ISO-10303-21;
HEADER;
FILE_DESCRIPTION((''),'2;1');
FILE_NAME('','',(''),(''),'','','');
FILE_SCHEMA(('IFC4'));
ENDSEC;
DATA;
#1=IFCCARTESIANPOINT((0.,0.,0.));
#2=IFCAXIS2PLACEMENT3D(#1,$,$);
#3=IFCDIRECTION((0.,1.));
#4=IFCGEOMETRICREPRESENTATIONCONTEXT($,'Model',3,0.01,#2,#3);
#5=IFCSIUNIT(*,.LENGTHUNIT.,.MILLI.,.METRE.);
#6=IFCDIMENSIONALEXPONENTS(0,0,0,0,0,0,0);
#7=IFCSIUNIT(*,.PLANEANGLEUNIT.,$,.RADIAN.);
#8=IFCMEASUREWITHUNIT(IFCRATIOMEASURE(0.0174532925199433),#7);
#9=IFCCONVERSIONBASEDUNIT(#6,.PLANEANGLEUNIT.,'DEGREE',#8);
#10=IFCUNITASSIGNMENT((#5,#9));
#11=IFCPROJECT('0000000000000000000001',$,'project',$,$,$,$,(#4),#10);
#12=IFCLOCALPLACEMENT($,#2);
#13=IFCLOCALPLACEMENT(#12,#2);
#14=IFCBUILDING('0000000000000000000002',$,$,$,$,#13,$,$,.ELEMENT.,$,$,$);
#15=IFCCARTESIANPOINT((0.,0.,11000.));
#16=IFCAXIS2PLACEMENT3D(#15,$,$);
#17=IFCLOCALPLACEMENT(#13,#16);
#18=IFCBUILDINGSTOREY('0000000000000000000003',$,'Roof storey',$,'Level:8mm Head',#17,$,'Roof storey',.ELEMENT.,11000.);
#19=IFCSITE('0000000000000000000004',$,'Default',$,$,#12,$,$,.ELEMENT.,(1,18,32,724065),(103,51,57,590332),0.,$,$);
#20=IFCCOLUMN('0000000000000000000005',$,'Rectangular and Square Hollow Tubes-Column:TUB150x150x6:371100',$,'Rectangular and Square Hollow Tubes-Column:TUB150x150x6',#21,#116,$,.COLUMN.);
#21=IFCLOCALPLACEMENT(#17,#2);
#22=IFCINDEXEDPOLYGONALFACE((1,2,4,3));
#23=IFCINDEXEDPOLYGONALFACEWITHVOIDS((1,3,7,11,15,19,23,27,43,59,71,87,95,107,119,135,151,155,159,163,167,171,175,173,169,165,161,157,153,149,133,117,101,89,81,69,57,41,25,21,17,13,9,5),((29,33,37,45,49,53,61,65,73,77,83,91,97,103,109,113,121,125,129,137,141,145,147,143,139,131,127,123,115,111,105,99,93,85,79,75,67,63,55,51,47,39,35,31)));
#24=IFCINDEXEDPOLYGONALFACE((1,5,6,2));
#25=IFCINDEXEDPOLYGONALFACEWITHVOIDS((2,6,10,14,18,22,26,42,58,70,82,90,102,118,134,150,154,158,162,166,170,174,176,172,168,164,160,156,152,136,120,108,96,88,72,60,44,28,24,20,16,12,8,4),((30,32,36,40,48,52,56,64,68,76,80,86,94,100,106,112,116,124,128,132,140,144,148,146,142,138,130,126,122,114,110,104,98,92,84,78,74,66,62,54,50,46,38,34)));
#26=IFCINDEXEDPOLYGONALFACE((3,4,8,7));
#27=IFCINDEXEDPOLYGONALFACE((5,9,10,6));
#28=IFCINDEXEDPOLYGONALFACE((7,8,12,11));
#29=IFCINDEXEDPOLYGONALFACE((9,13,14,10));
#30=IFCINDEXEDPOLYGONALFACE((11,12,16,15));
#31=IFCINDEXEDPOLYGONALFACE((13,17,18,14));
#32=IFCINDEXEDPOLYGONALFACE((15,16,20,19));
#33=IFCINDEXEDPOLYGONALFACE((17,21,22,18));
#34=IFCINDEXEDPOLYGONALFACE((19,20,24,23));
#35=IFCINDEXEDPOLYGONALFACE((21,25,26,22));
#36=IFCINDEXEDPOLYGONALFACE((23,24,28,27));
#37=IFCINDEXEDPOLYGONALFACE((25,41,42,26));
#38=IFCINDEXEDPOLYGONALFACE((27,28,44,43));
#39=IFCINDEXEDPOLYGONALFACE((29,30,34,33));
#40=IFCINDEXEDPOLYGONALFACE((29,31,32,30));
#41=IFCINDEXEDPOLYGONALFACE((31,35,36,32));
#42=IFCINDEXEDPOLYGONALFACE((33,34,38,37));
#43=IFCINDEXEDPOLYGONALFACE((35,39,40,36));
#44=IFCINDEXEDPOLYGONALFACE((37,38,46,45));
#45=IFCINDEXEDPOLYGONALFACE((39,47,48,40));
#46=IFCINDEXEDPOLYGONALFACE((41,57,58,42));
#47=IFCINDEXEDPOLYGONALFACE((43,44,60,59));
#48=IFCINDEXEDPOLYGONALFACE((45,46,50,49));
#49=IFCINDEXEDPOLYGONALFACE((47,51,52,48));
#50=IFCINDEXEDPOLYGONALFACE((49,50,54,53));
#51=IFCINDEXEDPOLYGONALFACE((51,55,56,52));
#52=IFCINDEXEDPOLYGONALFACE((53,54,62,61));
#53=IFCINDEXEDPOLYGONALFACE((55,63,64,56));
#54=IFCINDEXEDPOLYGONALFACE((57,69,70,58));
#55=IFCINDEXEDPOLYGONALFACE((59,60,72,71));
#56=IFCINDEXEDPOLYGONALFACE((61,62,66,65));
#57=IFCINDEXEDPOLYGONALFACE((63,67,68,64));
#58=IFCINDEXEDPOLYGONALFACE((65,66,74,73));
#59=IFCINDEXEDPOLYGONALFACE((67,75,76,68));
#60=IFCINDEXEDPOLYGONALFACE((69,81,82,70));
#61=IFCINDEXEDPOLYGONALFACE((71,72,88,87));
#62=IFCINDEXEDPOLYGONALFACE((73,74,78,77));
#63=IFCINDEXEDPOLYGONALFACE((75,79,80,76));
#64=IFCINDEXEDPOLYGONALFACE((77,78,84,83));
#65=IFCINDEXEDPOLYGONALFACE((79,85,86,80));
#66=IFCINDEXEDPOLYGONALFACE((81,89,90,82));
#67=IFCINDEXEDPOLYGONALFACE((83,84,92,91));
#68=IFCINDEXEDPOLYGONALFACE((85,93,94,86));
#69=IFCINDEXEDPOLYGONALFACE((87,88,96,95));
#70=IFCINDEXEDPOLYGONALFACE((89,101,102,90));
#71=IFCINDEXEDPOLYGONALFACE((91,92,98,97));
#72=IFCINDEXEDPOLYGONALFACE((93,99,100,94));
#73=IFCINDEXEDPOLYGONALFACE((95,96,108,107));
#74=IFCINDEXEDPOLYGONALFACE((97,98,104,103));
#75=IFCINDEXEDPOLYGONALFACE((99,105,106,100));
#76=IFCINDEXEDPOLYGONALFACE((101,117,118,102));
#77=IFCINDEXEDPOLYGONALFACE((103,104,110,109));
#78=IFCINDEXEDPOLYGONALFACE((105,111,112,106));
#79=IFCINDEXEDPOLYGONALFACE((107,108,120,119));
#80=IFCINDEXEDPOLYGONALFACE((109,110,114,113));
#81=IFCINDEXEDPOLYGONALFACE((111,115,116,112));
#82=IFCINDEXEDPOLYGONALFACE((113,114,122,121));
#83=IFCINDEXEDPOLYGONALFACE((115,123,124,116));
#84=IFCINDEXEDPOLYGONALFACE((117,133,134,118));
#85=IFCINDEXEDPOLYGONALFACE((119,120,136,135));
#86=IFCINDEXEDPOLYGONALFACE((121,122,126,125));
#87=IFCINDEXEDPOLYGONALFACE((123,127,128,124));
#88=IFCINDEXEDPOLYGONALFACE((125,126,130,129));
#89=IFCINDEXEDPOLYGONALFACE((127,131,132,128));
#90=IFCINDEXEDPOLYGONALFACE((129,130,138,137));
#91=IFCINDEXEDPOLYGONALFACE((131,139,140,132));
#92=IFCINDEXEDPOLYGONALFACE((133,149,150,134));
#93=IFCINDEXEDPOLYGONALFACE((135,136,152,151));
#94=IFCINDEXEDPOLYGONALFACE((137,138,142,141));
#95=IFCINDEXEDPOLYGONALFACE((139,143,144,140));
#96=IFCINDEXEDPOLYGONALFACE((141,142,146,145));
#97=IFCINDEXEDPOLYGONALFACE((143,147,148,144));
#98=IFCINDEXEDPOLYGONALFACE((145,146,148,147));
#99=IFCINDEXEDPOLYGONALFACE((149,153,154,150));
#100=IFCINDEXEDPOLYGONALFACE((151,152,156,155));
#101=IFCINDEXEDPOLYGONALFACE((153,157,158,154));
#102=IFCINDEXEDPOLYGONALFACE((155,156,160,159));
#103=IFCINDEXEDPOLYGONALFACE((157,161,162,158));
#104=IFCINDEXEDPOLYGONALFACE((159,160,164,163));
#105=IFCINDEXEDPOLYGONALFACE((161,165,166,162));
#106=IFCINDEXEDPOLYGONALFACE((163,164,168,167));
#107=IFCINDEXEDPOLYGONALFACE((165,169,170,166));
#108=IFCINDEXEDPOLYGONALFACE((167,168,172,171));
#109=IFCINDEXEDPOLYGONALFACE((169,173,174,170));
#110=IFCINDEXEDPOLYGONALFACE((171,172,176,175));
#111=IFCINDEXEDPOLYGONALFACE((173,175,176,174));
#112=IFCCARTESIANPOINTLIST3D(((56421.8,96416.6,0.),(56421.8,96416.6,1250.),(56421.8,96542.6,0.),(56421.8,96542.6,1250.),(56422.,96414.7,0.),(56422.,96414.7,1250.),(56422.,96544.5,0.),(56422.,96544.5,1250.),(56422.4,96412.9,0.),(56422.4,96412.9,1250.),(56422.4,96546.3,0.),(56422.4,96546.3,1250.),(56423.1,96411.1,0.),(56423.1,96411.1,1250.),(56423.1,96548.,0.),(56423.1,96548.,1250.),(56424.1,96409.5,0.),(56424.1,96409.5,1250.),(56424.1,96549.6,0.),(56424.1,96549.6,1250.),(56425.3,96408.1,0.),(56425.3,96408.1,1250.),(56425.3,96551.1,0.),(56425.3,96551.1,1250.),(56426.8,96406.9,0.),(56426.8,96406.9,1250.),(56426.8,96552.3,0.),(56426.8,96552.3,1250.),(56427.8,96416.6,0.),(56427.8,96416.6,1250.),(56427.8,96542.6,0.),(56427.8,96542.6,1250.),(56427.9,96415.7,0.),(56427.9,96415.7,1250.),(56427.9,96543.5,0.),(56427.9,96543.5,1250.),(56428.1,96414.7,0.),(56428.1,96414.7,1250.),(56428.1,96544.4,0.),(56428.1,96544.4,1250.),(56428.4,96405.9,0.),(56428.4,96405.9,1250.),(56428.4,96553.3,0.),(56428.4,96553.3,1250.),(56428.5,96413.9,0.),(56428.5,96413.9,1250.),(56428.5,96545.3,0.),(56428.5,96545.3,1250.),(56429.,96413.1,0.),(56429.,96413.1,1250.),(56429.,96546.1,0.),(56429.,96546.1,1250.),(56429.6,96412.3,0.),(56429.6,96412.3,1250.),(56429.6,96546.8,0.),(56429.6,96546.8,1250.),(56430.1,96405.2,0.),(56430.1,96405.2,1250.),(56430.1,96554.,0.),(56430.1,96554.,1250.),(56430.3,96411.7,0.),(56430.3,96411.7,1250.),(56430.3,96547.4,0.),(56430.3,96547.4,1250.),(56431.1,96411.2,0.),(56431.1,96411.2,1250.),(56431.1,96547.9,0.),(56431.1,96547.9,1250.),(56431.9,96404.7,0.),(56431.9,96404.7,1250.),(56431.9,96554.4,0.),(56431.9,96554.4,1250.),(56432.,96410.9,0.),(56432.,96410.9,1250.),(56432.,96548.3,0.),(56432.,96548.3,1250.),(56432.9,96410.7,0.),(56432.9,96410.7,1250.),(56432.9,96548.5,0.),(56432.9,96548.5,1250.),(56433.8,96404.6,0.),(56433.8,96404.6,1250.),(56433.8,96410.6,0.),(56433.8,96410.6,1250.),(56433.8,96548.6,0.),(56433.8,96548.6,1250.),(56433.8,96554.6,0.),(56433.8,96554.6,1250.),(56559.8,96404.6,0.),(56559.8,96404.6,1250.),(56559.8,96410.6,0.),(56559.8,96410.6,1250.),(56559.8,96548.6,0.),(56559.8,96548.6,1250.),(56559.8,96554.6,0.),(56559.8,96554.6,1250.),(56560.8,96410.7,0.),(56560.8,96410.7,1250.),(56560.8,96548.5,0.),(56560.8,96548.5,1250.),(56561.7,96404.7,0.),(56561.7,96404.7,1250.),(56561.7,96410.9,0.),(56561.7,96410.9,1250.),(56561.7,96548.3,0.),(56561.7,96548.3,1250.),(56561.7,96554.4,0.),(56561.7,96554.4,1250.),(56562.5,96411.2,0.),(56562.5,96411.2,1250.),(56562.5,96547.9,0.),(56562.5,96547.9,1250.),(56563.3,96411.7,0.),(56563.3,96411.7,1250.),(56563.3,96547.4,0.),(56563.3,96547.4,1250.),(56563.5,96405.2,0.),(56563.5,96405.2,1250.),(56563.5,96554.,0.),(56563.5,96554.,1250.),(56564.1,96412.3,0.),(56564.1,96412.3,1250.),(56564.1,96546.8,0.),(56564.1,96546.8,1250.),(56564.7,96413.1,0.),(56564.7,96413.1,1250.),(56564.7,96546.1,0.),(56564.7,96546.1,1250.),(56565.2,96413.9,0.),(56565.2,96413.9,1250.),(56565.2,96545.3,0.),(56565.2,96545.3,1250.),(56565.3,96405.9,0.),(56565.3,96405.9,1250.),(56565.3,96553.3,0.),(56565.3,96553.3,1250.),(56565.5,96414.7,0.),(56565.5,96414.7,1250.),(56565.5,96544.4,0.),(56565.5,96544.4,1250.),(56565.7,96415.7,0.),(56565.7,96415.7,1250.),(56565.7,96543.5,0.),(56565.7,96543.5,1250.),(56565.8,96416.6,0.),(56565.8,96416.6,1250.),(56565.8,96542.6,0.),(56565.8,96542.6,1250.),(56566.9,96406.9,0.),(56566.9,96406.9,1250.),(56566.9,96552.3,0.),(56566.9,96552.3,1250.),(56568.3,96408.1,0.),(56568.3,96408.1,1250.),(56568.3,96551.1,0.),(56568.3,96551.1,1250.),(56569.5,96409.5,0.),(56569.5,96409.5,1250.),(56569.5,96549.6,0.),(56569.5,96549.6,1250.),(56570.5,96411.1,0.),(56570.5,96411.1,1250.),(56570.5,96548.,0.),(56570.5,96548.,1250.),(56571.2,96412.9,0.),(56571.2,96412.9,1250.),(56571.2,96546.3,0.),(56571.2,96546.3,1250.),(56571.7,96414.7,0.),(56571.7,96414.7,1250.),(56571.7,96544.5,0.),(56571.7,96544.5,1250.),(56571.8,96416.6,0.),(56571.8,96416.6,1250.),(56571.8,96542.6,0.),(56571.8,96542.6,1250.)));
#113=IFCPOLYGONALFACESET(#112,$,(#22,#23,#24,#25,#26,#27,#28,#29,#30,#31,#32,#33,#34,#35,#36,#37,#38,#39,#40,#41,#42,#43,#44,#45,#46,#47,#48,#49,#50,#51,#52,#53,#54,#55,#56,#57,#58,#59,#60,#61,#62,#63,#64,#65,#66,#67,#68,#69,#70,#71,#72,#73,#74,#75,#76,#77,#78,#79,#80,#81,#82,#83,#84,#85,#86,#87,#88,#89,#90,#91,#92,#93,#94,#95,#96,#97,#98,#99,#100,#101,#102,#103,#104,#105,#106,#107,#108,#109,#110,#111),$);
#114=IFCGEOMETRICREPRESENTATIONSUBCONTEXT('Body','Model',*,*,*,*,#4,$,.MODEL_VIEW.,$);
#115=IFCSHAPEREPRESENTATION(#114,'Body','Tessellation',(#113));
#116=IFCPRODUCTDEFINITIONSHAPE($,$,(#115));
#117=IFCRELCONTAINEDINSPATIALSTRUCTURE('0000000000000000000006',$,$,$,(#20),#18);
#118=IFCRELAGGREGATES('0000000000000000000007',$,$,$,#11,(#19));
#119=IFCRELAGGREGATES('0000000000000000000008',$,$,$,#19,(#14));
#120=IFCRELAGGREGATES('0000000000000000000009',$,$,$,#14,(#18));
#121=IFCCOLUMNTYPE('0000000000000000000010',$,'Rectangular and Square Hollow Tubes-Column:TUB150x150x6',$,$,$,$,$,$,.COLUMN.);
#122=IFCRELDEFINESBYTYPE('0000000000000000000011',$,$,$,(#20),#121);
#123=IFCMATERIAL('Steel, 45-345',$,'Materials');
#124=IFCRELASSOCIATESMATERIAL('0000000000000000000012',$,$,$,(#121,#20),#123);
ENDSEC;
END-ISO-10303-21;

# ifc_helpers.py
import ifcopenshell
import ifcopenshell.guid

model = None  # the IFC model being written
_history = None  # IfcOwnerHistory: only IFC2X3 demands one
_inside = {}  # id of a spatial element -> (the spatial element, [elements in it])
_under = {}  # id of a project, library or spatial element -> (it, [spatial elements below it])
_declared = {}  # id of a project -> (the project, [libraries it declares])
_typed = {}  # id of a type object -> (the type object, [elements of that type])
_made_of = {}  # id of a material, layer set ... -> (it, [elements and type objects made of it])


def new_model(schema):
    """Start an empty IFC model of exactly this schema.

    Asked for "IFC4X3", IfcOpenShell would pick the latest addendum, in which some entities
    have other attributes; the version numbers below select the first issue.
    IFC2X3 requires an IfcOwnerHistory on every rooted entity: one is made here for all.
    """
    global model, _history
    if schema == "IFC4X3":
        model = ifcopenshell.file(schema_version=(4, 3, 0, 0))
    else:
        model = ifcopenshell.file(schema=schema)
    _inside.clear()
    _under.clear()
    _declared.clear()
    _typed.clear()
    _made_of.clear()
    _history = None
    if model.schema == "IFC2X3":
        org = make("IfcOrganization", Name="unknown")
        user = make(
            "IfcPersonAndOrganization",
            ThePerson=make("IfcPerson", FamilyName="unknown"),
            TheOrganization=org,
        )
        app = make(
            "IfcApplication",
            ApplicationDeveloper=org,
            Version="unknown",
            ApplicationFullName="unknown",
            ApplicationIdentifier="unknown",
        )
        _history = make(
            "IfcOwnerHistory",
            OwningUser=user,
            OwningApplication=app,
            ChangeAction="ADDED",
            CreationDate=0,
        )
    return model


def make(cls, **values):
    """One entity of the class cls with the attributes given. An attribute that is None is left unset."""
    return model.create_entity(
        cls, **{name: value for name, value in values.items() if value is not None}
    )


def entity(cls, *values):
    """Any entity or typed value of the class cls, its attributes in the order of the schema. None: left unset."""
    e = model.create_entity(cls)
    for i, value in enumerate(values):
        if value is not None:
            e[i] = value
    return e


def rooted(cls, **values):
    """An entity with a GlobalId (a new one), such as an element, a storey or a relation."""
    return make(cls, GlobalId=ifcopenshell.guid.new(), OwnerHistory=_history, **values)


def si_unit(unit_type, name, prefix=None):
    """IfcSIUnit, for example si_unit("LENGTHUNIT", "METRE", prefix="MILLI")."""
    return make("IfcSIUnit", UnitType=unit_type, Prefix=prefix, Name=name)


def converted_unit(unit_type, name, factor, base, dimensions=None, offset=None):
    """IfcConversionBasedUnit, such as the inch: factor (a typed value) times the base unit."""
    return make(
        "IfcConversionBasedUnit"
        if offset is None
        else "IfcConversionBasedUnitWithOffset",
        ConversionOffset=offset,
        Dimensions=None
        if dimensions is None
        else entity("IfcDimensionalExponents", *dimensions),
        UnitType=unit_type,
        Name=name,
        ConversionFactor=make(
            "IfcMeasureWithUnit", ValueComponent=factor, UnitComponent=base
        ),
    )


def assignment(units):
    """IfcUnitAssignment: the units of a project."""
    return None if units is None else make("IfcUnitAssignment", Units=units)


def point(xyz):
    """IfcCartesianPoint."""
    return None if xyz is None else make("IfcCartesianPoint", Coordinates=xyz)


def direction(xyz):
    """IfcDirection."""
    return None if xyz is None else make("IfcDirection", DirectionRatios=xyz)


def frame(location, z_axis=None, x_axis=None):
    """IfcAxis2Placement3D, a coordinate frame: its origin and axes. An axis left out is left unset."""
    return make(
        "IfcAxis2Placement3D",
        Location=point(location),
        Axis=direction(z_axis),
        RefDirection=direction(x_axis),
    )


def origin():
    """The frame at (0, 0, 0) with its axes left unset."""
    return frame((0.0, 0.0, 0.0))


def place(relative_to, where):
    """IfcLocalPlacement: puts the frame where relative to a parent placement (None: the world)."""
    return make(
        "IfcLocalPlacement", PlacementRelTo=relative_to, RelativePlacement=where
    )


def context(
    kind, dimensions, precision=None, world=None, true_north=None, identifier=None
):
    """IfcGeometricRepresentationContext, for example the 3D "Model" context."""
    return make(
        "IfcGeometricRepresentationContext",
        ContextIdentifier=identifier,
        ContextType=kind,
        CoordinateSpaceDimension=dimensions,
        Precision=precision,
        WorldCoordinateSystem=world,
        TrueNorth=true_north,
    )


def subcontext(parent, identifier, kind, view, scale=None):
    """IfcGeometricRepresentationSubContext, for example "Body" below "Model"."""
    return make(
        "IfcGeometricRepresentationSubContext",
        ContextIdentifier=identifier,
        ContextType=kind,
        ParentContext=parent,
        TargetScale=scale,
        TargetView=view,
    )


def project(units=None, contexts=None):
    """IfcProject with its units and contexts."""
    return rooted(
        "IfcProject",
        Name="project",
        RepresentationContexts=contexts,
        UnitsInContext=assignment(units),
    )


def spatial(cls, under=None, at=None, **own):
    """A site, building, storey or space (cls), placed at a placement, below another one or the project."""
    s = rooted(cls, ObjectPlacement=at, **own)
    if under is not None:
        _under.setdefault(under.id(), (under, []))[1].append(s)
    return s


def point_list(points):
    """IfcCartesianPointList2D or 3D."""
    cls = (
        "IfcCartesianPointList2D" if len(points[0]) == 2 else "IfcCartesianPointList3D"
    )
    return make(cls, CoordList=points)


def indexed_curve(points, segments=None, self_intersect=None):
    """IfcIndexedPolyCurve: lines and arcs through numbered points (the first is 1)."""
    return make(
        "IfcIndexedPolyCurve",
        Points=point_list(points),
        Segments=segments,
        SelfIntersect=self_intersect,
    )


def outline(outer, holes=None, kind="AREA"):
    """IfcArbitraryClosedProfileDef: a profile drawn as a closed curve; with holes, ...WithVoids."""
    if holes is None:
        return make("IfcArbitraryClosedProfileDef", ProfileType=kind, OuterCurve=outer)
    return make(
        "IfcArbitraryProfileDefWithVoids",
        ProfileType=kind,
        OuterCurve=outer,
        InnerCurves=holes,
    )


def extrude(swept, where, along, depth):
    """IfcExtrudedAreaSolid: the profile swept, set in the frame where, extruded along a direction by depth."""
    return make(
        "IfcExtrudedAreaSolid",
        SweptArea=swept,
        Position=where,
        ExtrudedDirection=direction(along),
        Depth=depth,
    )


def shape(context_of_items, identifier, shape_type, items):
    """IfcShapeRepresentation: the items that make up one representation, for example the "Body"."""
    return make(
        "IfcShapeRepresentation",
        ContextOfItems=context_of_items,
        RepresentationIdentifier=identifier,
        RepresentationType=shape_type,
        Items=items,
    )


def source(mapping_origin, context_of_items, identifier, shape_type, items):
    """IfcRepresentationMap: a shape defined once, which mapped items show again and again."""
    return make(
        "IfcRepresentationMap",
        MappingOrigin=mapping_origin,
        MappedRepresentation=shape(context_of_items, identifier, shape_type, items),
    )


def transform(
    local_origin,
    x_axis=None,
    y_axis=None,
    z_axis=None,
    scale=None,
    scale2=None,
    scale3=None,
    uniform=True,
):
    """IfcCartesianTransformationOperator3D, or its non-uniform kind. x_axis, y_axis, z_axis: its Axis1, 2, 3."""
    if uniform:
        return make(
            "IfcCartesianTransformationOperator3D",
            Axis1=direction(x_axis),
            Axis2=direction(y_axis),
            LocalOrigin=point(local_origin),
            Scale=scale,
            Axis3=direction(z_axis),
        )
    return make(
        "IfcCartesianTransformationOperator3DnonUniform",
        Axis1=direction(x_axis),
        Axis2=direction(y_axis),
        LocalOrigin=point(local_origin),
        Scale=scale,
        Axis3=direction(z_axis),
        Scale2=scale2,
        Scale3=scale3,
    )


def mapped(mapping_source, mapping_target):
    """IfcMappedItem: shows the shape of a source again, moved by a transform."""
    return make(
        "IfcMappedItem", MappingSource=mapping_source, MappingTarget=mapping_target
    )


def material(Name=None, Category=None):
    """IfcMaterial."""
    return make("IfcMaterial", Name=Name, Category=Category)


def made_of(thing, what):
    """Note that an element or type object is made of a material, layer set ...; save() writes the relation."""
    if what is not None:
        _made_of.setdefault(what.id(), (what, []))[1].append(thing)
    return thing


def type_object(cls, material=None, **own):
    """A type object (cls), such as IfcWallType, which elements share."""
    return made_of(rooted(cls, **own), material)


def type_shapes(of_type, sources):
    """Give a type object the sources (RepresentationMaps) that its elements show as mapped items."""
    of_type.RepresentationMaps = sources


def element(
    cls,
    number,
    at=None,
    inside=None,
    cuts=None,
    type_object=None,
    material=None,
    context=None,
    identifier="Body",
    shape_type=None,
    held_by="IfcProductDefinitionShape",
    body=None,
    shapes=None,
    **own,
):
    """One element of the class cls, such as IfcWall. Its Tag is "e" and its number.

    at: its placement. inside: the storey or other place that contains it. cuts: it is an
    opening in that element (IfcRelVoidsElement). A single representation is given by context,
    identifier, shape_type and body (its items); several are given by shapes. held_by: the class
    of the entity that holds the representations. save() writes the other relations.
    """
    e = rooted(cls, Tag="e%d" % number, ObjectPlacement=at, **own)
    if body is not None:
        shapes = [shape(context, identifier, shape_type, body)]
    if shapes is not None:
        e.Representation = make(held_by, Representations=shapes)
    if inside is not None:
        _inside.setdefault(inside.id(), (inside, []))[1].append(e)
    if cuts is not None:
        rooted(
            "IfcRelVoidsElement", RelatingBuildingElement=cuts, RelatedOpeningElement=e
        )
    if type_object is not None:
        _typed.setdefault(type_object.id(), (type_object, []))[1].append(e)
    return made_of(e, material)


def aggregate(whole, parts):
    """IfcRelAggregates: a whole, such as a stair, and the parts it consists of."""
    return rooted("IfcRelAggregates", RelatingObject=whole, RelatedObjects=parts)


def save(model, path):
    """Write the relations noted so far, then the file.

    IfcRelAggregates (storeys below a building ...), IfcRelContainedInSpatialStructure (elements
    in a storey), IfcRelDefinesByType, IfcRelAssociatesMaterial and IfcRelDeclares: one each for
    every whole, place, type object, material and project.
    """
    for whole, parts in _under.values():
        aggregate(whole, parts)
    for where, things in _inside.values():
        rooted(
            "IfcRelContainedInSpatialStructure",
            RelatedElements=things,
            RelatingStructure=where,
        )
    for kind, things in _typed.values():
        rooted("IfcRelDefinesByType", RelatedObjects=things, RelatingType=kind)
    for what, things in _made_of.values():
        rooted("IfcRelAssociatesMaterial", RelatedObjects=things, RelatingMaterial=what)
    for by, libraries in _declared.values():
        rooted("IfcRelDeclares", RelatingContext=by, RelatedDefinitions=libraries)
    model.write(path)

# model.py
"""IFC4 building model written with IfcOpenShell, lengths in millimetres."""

from ifc_helpers import new_model, entity, si_unit, converted_unit, direction, frame, origin, place, context, subcontext, project, spatial, indexed_curve, outline, extrude, source, transform, mapped, material, type_object, type_shapes, element, save


model = new_model("IFC4")

# Units and contexts
model_context = context("Model", 3, precision=0.01, world=origin(), true_north=direction((0.0, 1.0)))
body_context = subcontext(model_context, "Body", "Model", "MODEL_VIEW")
ifc_project = project(units=[si_unit("LENGTHUNIT", "METRE", prefix="MILLI"), converted_unit("PLANEANGLEUNIT", "DEGREE", entity("IfcRatioMeasure", 0.0174532925199433), si_unit("PLANEANGLEUNIT", "RADIAN"), dimensions=[0, 0, 0, 0, 0, 0, 0])], contexts=[model_context])

# Site, building, storey
site_placement = place(None, origin())
site = spatial("IfcSite", under=ifc_project, at=site_placement, Name="Default", CompositionType="ELEMENT", RefLatitude=(1, 18, 32, 724065), RefLongitude=(103, 51, 57, 590332), RefElevation=0.0)
building_placement = place(site_placement, origin())
building = spatial("IfcBuilding", under=site, at=building_placement, CompositionType="ELEMENT")
storey_placement = place(building_placement, frame((0.0, 0.0, 11000.0)))
storey = spatial("IfcBuildingStorey", under=building, at=storey_placement, Name="Roof storey", ObjectType="Level:8mm Head", LongName="Roof storey", CompositionType="ELEMENT", Elevation=11000.0)

# Column
ifc_material = material(Name="Steel, 45-345", Category="Materials")
column_type = type_object("IfcColumnType", Name="Rectangular and Square Hollow Tubes-Column:TUB150x150x6", PredefinedType="COLUMN", material=ifc_material)
shared_shape_1 = source(origin(), body_context, "Body", "SweptSolid", [
    extrude(outline(indexed_curve([(-63.0, -75.0), (63.0, -75.0), (64.9, -74.9), (66.7, -74.4), (68.4, -73.7), (70.1, -72.7), (71.5, -71.5), (72.7, -70.1), (73.7, -68.4), (74.4, -66.7), (74.9, -64.9), (75.0, -63.0), (75.0, 63.0), (74.9, 64.9), (74.4, 66.7), (73.7, 68.4), (72.7, 70.1), (71.5, 71.5), (70.1, 72.7), (68.4, 73.7), (66.7, 74.4), (64.9, 74.9), (63.0, 75.0), (-63.0, 75.0), (-64.9, 74.9), (-66.7, 74.4), (-68.4, 73.7), (-70.1, 72.7), (-71.5, 71.5), (-72.7, 70.1), (-73.7, 68.4), (-74.4, 66.7), (-74.9, 64.9), (-75.0, 63.0), (-75.0, -63.0), (-74.9, -64.9), (-74.4, -66.7), (-73.7, -68.4), (-72.7, -70.1), (-71.5, -71.5), (-70.1, -72.7), (-68.4, -73.7), (-66.7, -74.4), (-64.9, -74.9), (-63.0, -75.0)], self_intersect=False), holes=[indexed_curve([(-63.0, -69.0), (-63.9, -68.9), (-64.9, -68.7), (-65.7, -68.3), (-66.5, -67.9), (-67.2, -67.2), (-67.9, -66.5), (-68.3, -65.7), (-68.7, -64.9), (-68.9, -63.9), (-69.0, -63.0), (-69.0, 63.0), (-68.9, 63.9), (-68.7, 64.9), (-68.3, 65.7), (-67.9, 66.5), (-67.2, 67.2), (-66.5, 67.9), (-65.7, 68.3), (-64.9, 68.7), (-63.9, 68.9), (-63.0, 69.0), (63.0, 69.0), (63.9, 68.9), (64.9, 68.7), (65.7, 68.3), (66.5, 67.9), (67.2, 67.2), (67.9, 66.5), (68.3, 65.7), (68.7, 64.9), (68.9, 63.9), (69.0, 63.0), (69.0, -63.0), (68.9, -63.9), (68.7, -64.9), (68.3, -65.7), (67.9, -66.5), (67.2, -67.2), (66.5, -67.9), (65.7, -68.3), (64.9, -68.7), (63.9, -68.9), (63.0, -69.0), (-63.0, -69.0)], self_intersect=False)]), frame((0.0, 0.0, 11000.0), z_axis=(0.0, 0.0, 1.0), x_axis=(-1.0, 0.0, 0.0)), (0.0, 0.0, 1.0), 1250.0),
])
type_shapes(column_type, [shared_shape_1])
for number, where, name in (
    (1, (56496.8, 96479.6, -11000.0), "Rectangular and Square Hollow Tubes-Column:TUB150x150x6:371100"),
):
    element("IfcColumn", number, at=place(storey_placement, frame(where)), inside=storey, type_object=column_type, material=ifc_material, Name=name, ObjectType="Rectangular and Square Hollow Tubes-Column:TUB150x150x6", PredefinedType="COLUMN", context=body_context, shape_type="MappedRepresentation", body=[
        mapped(shared_shape_1, transform((0.0, 0.0, 0.0), scale=1.0)),
    ])

save(model, "model.ifc")
